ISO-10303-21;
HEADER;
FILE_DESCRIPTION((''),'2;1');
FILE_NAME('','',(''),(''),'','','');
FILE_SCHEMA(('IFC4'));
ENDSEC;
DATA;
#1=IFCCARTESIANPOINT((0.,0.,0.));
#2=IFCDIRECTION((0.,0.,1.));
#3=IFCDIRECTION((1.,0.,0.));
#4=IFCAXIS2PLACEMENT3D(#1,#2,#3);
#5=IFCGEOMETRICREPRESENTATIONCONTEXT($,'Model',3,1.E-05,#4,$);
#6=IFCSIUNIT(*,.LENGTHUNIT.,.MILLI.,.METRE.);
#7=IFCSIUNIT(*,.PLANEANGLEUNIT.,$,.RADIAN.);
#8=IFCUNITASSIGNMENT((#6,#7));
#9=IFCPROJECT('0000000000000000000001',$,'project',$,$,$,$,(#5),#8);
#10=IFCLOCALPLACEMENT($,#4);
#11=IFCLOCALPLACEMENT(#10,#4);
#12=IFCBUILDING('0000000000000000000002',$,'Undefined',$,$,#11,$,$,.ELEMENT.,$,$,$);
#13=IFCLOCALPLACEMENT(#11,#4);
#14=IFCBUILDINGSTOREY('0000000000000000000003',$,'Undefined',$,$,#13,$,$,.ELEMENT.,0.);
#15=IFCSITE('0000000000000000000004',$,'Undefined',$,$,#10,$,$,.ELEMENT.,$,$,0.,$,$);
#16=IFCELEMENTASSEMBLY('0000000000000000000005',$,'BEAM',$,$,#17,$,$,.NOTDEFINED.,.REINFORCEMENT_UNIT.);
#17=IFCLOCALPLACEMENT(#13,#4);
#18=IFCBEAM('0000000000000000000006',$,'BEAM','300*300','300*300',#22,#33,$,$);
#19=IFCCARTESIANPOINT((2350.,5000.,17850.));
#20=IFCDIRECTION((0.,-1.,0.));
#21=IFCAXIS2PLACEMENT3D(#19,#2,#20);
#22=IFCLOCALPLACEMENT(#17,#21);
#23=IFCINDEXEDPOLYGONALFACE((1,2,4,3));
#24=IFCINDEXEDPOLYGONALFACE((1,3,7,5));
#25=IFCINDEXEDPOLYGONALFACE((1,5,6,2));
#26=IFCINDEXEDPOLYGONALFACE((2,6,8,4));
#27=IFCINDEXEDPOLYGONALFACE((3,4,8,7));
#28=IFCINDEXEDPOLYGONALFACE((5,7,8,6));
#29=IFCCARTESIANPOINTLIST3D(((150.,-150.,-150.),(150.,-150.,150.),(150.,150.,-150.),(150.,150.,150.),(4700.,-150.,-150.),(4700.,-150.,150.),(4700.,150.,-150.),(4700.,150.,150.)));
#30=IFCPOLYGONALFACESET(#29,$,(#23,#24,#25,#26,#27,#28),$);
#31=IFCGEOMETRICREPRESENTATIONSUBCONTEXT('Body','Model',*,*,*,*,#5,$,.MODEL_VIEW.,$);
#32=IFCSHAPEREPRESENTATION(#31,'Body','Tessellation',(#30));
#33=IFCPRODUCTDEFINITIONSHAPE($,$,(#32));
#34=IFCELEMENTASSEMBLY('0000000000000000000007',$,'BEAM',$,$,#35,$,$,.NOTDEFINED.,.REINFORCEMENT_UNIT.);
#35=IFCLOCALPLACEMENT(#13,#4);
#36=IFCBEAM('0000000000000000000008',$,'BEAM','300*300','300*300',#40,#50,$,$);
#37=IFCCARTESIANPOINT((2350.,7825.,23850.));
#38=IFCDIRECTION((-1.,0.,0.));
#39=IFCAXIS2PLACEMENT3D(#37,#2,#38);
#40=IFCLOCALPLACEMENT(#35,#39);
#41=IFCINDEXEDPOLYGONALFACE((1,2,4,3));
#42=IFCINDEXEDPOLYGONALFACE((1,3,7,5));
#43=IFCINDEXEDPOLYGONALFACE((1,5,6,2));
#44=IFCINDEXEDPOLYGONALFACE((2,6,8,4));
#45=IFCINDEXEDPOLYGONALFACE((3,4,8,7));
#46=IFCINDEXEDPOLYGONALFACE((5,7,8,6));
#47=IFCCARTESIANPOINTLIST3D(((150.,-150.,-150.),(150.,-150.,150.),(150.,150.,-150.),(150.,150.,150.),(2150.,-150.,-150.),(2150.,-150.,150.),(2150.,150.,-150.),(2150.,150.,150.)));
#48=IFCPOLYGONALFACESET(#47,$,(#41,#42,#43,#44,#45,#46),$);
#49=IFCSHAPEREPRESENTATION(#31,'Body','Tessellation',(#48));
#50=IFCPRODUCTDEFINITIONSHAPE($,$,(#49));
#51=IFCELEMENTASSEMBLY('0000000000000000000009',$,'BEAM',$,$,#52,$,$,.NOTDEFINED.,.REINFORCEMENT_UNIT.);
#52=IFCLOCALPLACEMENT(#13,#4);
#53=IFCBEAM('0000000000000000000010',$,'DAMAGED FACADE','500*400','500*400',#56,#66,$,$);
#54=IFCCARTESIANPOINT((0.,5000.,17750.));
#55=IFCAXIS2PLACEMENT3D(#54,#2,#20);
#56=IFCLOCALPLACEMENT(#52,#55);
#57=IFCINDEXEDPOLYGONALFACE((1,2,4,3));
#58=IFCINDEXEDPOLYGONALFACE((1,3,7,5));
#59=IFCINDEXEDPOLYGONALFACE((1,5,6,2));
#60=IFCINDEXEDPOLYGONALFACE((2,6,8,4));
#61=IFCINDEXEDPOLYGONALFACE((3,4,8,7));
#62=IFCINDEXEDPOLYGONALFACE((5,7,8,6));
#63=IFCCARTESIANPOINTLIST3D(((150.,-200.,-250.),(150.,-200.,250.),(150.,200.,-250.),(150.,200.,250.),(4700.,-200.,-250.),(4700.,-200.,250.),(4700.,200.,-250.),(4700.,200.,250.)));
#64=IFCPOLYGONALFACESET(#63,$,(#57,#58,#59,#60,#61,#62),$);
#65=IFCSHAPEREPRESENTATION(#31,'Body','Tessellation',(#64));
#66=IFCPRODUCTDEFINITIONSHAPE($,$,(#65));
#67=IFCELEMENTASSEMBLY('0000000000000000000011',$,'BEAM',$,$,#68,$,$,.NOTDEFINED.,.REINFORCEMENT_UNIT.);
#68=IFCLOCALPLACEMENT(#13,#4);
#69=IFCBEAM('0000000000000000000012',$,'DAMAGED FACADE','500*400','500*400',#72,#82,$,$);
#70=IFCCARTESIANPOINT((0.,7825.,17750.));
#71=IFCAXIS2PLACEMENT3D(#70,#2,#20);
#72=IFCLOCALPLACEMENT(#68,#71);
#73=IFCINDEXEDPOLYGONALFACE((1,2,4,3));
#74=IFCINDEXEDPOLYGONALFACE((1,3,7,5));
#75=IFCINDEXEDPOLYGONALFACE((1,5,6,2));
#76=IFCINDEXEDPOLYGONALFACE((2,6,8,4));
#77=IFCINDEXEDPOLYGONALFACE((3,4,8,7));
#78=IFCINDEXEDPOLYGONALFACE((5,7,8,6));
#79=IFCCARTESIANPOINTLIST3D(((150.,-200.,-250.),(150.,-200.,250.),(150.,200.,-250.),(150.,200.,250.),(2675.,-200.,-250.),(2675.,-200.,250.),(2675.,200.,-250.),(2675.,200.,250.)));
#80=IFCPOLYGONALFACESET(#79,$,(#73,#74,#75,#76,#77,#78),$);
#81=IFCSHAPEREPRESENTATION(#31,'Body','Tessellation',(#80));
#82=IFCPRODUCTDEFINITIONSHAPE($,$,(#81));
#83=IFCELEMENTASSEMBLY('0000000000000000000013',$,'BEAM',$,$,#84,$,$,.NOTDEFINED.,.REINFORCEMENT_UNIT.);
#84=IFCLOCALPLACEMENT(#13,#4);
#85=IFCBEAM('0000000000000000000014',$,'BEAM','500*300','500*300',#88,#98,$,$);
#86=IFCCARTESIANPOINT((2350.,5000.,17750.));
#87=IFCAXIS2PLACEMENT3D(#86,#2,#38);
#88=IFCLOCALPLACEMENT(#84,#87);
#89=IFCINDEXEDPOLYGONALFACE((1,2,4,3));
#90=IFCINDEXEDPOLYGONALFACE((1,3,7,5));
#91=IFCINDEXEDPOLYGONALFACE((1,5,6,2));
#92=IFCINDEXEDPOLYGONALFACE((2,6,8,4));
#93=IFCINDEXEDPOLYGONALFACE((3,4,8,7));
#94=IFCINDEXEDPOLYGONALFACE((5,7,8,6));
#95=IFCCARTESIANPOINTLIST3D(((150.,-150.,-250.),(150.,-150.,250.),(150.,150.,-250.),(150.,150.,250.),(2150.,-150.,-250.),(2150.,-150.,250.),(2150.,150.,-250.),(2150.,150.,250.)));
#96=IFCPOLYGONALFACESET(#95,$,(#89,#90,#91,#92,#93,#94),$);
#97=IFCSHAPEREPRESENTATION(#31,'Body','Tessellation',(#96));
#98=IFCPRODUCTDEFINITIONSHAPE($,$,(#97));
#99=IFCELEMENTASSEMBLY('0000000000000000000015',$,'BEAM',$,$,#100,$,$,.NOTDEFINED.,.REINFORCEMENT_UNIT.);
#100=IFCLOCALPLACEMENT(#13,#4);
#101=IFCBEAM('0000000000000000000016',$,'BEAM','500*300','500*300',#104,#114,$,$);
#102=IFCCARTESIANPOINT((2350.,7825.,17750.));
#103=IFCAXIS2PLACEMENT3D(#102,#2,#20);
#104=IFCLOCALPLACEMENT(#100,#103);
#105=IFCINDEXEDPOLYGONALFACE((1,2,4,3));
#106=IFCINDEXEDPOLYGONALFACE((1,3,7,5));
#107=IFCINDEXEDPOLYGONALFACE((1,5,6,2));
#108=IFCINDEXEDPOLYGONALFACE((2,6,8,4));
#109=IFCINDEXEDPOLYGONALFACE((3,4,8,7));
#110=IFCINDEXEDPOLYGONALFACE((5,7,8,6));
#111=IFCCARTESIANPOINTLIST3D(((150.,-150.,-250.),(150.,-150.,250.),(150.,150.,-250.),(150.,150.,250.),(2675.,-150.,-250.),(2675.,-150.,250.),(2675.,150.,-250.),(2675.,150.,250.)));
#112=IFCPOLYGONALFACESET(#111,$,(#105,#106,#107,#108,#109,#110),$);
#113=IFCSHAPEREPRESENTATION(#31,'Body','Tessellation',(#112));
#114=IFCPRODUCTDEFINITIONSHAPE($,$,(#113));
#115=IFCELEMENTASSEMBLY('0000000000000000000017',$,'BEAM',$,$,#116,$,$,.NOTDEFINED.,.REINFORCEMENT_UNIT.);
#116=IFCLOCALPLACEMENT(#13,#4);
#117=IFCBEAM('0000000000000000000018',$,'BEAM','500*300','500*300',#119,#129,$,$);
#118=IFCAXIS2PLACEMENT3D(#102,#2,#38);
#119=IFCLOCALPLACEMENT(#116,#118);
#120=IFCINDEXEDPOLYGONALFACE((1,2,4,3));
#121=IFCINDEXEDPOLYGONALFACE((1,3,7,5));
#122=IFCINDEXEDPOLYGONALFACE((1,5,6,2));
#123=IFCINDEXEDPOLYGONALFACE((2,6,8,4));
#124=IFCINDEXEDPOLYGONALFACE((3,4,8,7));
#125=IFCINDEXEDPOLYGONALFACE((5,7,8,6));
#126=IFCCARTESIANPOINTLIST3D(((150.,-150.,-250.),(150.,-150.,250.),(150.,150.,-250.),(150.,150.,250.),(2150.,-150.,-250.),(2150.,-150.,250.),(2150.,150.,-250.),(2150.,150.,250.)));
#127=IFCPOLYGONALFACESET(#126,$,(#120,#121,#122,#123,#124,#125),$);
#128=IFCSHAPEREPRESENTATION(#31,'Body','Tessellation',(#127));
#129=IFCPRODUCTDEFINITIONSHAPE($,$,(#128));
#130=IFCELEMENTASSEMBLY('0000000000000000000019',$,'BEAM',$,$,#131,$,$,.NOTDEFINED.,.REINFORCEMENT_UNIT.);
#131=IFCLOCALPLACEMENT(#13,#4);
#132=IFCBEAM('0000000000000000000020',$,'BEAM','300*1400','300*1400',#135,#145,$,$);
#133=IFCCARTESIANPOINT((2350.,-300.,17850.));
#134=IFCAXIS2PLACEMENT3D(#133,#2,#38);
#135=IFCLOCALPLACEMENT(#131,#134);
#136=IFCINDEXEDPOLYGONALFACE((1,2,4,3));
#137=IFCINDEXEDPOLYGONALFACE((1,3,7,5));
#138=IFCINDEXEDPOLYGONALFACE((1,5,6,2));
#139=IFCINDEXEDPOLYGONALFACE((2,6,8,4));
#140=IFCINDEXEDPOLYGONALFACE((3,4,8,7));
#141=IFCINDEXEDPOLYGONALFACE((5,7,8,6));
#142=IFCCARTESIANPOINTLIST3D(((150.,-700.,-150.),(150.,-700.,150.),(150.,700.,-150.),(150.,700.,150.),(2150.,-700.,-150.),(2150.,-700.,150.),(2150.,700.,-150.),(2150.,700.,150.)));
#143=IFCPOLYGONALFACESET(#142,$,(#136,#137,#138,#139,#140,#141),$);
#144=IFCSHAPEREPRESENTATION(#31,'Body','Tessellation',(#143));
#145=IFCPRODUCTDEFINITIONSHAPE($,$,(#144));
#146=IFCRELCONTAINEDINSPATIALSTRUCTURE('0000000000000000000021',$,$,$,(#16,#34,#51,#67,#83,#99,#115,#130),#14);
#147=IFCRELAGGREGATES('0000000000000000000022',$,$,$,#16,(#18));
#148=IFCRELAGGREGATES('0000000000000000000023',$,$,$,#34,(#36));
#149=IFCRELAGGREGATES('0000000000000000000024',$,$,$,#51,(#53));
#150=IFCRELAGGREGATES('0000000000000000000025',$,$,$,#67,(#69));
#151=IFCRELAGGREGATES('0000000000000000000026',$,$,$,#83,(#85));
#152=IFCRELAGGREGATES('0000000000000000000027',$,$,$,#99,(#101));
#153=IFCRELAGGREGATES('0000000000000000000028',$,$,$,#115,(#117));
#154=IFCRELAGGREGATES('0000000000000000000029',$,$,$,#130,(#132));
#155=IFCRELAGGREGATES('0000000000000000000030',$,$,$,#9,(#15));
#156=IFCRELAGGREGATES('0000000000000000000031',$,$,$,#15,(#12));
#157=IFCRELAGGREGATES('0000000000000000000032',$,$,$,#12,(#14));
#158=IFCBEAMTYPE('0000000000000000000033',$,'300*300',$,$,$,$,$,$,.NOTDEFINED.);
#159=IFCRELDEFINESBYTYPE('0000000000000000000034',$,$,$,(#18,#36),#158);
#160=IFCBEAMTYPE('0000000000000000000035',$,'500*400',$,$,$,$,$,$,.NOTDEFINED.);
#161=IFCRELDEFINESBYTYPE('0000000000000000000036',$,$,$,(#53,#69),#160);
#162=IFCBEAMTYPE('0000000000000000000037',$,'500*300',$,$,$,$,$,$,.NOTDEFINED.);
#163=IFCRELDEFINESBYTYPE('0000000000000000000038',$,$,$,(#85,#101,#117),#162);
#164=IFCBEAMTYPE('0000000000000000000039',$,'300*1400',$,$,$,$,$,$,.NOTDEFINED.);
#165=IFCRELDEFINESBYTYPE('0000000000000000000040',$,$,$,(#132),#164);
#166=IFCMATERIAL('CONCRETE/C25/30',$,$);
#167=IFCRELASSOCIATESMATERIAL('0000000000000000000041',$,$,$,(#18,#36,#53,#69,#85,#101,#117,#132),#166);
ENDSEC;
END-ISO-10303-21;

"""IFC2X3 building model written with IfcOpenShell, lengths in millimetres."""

from ifc_helpers import new_model, si_unit, frame, origin_with_axes, origin_2d_with_axis, place, context, subcontext, project, spatial, rectangle, extrude, material, type_object, element, aggregate, save


model = new_model("IFC2X3")

# Units and contexts
model_context = context("Model", 3, precision=1e-05, world=origin_with_axes())
body_context = subcontext(model_context, "Body", "Model", "MODEL_VIEW")
ifc_project = project(units=[si_unit("LENGTHUNIT", "METRE", prefix="MILLI"), si_unit("PLANEANGLEUNIT", "RADIAN")], contexts=[model_context])

# Site, building, storey
site_placement = place(None, origin_with_axes())
site = spatial("IfcSite", under=ifc_project, at=site_placement, Name="Undefined", CompositionType="ELEMENT", RefElevation=0.0)
building_placement = place(site_placement, origin_with_axes())
building = spatial("IfcBuilding", under=site, at=building_placement, Name="Undefined", CompositionType="ELEMENT")
storey_placement = place(building_placement, origin_with_axes())
storey = spatial("IfcBuildingStorey", under=building, at=storey_placement, Name="Undefined", CompositionType="ELEMENT", Elevation=0.0)

# Shared definitions
ifc_material_1 = material(Name="CONCRETE/C25/30")

# Element assemblies, beams
assembly_1_placement = place(storey_placement, origin_with_axes())
assembly_1 = element("IfcElementAssembly", 1, at=assembly_1_placement, inside=storey, Name="BEAM", AssemblyPlace="NOTDEFINED", PredefinedType="REINFORCEMENT_UNIT")
beam_type_1 = type_object("IfcBeamType", Name="300*300", PredefinedType="NOTDEFINED")
beam_1_placement = place(assembly_1_placement, frame((2350.0, 5000.0, 17850.0), z_axis=(0.0, 0.0, 1.0), x_axis=(0.0, -1.0, 0.0)))
beam_1 = element("IfcBeam", 2, at=beam_1_placement, type_object=beam_type_1, material=ifc_material_1, Name="BEAM", Description="300*300", ObjectType="300*300", context=body_context, shape_type="SweptSolid", body=[
    extrude(rectangle(XDim=300.0, YDim=300.0, at=origin_2d_with_axis()), frame((4700.0, 0.0, 0.0), z_axis=(-1.0, 0.0, 0.0), x_axis=(0.0, -1.0, 0.0)), (0.0, 0.0, 1.0), 4550.0),
])
aggregate(assembly_1, [beam_1])
assembly_2_placement = place(storey_placement, origin_with_axes())
assembly_2 = element("IfcElementAssembly", 3, at=assembly_2_placement, inside=storey, Name="BEAM", AssemblyPlace="NOTDEFINED", PredefinedType="REINFORCEMENT_UNIT")
beam_2_placement = place(assembly_2_placement, frame((2350.0, 7825.0, 23850.0), z_axis=(0.0, 0.0, 1.0), x_axis=(-1.0, 0.0, 0.0)))
beam_2 = element("IfcBeam", 4, at=beam_2_placement, type_object=beam_type_1, material=ifc_material_1, Name="BEAM", Description="300*300", ObjectType="300*300", context=body_context, shape_type="SweptSolid", body=[
    extrude(rectangle(XDim=300.0, YDim=300.0, at=origin_2d_with_axis()), frame((2150.0, 0.0, 0.0), z_axis=(-1.0, 0.0, 0.0), x_axis=(0.0, -1.0, 0.0)), (0.0, 0.0, 1.0), 2000.0),
])
aggregate(assembly_2, [beam_2])
assembly_3_placement = place(storey_placement, origin_with_axes())
assembly_3 = element("IfcElementAssembly", 5, at=assembly_3_placement, inside=storey, Name="BEAM", AssemblyPlace="NOTDEFINED", PredefinedType="REINFORCEMENT_UNIT")
beam_type_2 = type_object("IfcBeamType", Name="500*400", PredefinedType="NOTDEFINED")
beam_3_placement = place(assembly_3_placement, frame((0.0, 5000.0, 17750.0), z_axis=(0.0, 0.0, 1.0), x_axis=(0.0, -1.0, 0.0)))
beam_3 = element("IfcBeam", 6, at=beam_3_placement, type_object=beam_type_2, material=ifc_material_1, Name="DAMAGED FACADE", Description="500*400", ObjectType="500*400", context=body_context, shape_type="SweptSolid", body=[
    extrude(rectangle(XDim=400.0, YDim=500.0, at=origin_2d_with_axis()), frame((4700.0, 0.0, 0.0), z_axis=(-1.0, 0.0, 0.0), x_axis=(0.0, -1.0, 0.0)), (0.0, 0.0, 1.0), 4550.0),
])
aggregate(assembly_3, [beam_3])
assembly_4_placement = place(storey_placement, origin_with_axes())
assembly_4 = element("IfcElementAssembly", 7, at=assembly_4_placement, inside=storey, Name="BEAM", AssemblyPlace="NOTDEFINED", PredefinedType="REINFORCEMENT_UNIT")
beam_4_placement = place(assembly_4_placement, frame((0.0, 7825.0, 17750.0), z_axis=(0.0, 0.0, 1.0), x_axis=(0.0, -1.0, 0.0)))
beam_4 = element("IfcBeam", 8, at=beam_4_placement, type_object=beam_type_2, material=ifc_material_1, Name="DAMAGED FACADE", Description="500*400", ObjectType="500*400", context=body_context, shape_type="SweptSolid", body=[
    extrude(rectangle(XDim=400.0, YDim=500.0, at=origin_2d_with_axis()), frame((2675.0, 0.0, 0.0), z_axis=(-1.0, 0.0, 0.0), x_axis=(0.0, -1.0, 0.0)), (0.0, 0.0, 1.0), 2525.0),
])
aggregate(assembly_4, [beam_4])
assembly_5_placement = place(storey_placement, origin_with_axes())
assembly_5 = element("IfcElementAssembly", 9, at=assembly_5_placement, inside=storey, Name="BEAM", AssemblyPlace="NOTDEFINED", PredefinedType="REINFORCEMENT_UNIT")
beam_type_3 = type_object("IfcBeamType", Name="500*300", PredefinedType="NOTDEFINED")
beam_5_placement = place(assembly_5_placement, frame((2350.0, 5000.0, 17750.0), z_axis=(0.0, 0.0, 1.0), x_axis=(-1.0, 0.0, 0.0)))
beam_5 = element("IfcBeam", 10, at=beam_5_placement, type_object=beam_type_3, material=ifc_material_1, Name="BEAM", Description="500*300", ObjectType="500*300", context=body_context, shape_type="SweptSolid", body=[
    extrude(rectangle(XDim=300.0, YDim=500.0, at=origin_2d_with_axis()), frame((2150.0, 0.0, 0.0), z_axis=(-1.0, 0.0, 0.0), x_axis=(0.0, -1.0, 0.0)), (0.0, 0.0, 1.0), 2000.0),
])
aggregate(assembly_5, [beam_5])
assembly_6_placement = place(storey_placement, origin_with_axes())
assembly_6 = element("IfcElementAssembly", 11, at=assembly_6_placement, inside=storey, Name="BEAM", AssemblyPlace="NOTDEFINED", PredefinedType="REINFORCEMENT_UNIT")
beam_6_placement = place(assembly_6_placement, frame((2350.0, 7825.0, 17750.0), z_axis=(0.0, 0.0, 1.0), x_axis=(0.0, -1.0, 0.0)))
beam_6 = element("IfcBeam", 12, at=beam_6_placement, type_object=beam_type_3, material=ifc_material_1, Name="BEAM", Description="500*300", ObjectType="500*300", context=body_context, shape_type="SweptSolid", body=[
    extrude(rectangle(XDim=300.0, YDim=500.0, at=origin_2d_with_axis()), frame((2675.0, 0.0, 0.0), z_axis=(-1.0, 0.0, 0.0), x_axis=(0.0, -1.0, 0.0)), (0.0, 0.0, 1.0), 2525.0),
])
aggregate(assembly_6, [beam_6])
assembly_7_placement = place(storey_placement, origin_with_axes())
assembly_7 = element("IfcElementAssembly", 13, at=assembly_7_placement, inside=storey, Name="BEAM", AssemblyPlace="NOTDEFINED", PredefinedType="REINFORCEMENT_UNIT")
beam_7_placement = place(assembly_7_placement, frame((2350.0, 7825.0, 17750.0), z_axis=(0.0, 0.0, 1.0), x_axis=(-1.0, 0.0, 0.0)))
beam_7 = element("IfcBeam", 14, at=beam_7_placement, type_object=beam_type_3, material=ifc_material_1, Name="BEAM", Description="500*300", ObjectType="500*300", context=body_context, shape_type="SweptSolid", body=[
    extrude(rectangle(XDim=300.0, YDim=500.0, at=origin_2d_with_axis()), frame((2150.0, 0.0, 0.0), z_axis=(-1.0, 0.0, 0.0), x_axis=(0.0, -1.0, 0.0)), (0.0, 0.0, 1.0), 2000.0),
])
aggregate(assembly_7, [beam_7])
assembly_8_placement = place(storey_placement, origin_with_axes())
assembly_8 = element("IfcElementAssembly", 15, at=assembly_8_placement, inside=storey, Name="BEAM", AssemblyPlace="NOTDEFINED", PredefinedType="REINFORCEMENT_UNIT")
beam_type_4 = type_object("IfcBeamType", Name="300*1400", PredefinedType="NOTDEFINED")
beam_8_placement = place(assembly_8_placement, frame((2350.0, -300.0, 17850.0), z_axis=(0.0, 0.0, 1.0), x_axis=(-1.0, 0.0, 0.0)))
beam_8 = element("IfcBeam", 16, at=beam_8_placement, type_object=beam_type_4, material=ifc_material_1, Name="BEAM", Description="300*1400", ObjectType="300*1400", context=body_context, shape_type="SweptSolid", body=[
    extrude(rectangle(XDim=1400.0, YDim=300.0, at=origin_2d_with_axis()), frame((2150.0, 0.0, 0.0), z_axis=(-1.0, 0.0, 0.0), x_axis=(0.0, -1.0, 0.0)), (0.0, 0.0, 1.0), 2000.0),
])
aggregate(assembly_8, [beam_8])

save(model, "model.ifc")
